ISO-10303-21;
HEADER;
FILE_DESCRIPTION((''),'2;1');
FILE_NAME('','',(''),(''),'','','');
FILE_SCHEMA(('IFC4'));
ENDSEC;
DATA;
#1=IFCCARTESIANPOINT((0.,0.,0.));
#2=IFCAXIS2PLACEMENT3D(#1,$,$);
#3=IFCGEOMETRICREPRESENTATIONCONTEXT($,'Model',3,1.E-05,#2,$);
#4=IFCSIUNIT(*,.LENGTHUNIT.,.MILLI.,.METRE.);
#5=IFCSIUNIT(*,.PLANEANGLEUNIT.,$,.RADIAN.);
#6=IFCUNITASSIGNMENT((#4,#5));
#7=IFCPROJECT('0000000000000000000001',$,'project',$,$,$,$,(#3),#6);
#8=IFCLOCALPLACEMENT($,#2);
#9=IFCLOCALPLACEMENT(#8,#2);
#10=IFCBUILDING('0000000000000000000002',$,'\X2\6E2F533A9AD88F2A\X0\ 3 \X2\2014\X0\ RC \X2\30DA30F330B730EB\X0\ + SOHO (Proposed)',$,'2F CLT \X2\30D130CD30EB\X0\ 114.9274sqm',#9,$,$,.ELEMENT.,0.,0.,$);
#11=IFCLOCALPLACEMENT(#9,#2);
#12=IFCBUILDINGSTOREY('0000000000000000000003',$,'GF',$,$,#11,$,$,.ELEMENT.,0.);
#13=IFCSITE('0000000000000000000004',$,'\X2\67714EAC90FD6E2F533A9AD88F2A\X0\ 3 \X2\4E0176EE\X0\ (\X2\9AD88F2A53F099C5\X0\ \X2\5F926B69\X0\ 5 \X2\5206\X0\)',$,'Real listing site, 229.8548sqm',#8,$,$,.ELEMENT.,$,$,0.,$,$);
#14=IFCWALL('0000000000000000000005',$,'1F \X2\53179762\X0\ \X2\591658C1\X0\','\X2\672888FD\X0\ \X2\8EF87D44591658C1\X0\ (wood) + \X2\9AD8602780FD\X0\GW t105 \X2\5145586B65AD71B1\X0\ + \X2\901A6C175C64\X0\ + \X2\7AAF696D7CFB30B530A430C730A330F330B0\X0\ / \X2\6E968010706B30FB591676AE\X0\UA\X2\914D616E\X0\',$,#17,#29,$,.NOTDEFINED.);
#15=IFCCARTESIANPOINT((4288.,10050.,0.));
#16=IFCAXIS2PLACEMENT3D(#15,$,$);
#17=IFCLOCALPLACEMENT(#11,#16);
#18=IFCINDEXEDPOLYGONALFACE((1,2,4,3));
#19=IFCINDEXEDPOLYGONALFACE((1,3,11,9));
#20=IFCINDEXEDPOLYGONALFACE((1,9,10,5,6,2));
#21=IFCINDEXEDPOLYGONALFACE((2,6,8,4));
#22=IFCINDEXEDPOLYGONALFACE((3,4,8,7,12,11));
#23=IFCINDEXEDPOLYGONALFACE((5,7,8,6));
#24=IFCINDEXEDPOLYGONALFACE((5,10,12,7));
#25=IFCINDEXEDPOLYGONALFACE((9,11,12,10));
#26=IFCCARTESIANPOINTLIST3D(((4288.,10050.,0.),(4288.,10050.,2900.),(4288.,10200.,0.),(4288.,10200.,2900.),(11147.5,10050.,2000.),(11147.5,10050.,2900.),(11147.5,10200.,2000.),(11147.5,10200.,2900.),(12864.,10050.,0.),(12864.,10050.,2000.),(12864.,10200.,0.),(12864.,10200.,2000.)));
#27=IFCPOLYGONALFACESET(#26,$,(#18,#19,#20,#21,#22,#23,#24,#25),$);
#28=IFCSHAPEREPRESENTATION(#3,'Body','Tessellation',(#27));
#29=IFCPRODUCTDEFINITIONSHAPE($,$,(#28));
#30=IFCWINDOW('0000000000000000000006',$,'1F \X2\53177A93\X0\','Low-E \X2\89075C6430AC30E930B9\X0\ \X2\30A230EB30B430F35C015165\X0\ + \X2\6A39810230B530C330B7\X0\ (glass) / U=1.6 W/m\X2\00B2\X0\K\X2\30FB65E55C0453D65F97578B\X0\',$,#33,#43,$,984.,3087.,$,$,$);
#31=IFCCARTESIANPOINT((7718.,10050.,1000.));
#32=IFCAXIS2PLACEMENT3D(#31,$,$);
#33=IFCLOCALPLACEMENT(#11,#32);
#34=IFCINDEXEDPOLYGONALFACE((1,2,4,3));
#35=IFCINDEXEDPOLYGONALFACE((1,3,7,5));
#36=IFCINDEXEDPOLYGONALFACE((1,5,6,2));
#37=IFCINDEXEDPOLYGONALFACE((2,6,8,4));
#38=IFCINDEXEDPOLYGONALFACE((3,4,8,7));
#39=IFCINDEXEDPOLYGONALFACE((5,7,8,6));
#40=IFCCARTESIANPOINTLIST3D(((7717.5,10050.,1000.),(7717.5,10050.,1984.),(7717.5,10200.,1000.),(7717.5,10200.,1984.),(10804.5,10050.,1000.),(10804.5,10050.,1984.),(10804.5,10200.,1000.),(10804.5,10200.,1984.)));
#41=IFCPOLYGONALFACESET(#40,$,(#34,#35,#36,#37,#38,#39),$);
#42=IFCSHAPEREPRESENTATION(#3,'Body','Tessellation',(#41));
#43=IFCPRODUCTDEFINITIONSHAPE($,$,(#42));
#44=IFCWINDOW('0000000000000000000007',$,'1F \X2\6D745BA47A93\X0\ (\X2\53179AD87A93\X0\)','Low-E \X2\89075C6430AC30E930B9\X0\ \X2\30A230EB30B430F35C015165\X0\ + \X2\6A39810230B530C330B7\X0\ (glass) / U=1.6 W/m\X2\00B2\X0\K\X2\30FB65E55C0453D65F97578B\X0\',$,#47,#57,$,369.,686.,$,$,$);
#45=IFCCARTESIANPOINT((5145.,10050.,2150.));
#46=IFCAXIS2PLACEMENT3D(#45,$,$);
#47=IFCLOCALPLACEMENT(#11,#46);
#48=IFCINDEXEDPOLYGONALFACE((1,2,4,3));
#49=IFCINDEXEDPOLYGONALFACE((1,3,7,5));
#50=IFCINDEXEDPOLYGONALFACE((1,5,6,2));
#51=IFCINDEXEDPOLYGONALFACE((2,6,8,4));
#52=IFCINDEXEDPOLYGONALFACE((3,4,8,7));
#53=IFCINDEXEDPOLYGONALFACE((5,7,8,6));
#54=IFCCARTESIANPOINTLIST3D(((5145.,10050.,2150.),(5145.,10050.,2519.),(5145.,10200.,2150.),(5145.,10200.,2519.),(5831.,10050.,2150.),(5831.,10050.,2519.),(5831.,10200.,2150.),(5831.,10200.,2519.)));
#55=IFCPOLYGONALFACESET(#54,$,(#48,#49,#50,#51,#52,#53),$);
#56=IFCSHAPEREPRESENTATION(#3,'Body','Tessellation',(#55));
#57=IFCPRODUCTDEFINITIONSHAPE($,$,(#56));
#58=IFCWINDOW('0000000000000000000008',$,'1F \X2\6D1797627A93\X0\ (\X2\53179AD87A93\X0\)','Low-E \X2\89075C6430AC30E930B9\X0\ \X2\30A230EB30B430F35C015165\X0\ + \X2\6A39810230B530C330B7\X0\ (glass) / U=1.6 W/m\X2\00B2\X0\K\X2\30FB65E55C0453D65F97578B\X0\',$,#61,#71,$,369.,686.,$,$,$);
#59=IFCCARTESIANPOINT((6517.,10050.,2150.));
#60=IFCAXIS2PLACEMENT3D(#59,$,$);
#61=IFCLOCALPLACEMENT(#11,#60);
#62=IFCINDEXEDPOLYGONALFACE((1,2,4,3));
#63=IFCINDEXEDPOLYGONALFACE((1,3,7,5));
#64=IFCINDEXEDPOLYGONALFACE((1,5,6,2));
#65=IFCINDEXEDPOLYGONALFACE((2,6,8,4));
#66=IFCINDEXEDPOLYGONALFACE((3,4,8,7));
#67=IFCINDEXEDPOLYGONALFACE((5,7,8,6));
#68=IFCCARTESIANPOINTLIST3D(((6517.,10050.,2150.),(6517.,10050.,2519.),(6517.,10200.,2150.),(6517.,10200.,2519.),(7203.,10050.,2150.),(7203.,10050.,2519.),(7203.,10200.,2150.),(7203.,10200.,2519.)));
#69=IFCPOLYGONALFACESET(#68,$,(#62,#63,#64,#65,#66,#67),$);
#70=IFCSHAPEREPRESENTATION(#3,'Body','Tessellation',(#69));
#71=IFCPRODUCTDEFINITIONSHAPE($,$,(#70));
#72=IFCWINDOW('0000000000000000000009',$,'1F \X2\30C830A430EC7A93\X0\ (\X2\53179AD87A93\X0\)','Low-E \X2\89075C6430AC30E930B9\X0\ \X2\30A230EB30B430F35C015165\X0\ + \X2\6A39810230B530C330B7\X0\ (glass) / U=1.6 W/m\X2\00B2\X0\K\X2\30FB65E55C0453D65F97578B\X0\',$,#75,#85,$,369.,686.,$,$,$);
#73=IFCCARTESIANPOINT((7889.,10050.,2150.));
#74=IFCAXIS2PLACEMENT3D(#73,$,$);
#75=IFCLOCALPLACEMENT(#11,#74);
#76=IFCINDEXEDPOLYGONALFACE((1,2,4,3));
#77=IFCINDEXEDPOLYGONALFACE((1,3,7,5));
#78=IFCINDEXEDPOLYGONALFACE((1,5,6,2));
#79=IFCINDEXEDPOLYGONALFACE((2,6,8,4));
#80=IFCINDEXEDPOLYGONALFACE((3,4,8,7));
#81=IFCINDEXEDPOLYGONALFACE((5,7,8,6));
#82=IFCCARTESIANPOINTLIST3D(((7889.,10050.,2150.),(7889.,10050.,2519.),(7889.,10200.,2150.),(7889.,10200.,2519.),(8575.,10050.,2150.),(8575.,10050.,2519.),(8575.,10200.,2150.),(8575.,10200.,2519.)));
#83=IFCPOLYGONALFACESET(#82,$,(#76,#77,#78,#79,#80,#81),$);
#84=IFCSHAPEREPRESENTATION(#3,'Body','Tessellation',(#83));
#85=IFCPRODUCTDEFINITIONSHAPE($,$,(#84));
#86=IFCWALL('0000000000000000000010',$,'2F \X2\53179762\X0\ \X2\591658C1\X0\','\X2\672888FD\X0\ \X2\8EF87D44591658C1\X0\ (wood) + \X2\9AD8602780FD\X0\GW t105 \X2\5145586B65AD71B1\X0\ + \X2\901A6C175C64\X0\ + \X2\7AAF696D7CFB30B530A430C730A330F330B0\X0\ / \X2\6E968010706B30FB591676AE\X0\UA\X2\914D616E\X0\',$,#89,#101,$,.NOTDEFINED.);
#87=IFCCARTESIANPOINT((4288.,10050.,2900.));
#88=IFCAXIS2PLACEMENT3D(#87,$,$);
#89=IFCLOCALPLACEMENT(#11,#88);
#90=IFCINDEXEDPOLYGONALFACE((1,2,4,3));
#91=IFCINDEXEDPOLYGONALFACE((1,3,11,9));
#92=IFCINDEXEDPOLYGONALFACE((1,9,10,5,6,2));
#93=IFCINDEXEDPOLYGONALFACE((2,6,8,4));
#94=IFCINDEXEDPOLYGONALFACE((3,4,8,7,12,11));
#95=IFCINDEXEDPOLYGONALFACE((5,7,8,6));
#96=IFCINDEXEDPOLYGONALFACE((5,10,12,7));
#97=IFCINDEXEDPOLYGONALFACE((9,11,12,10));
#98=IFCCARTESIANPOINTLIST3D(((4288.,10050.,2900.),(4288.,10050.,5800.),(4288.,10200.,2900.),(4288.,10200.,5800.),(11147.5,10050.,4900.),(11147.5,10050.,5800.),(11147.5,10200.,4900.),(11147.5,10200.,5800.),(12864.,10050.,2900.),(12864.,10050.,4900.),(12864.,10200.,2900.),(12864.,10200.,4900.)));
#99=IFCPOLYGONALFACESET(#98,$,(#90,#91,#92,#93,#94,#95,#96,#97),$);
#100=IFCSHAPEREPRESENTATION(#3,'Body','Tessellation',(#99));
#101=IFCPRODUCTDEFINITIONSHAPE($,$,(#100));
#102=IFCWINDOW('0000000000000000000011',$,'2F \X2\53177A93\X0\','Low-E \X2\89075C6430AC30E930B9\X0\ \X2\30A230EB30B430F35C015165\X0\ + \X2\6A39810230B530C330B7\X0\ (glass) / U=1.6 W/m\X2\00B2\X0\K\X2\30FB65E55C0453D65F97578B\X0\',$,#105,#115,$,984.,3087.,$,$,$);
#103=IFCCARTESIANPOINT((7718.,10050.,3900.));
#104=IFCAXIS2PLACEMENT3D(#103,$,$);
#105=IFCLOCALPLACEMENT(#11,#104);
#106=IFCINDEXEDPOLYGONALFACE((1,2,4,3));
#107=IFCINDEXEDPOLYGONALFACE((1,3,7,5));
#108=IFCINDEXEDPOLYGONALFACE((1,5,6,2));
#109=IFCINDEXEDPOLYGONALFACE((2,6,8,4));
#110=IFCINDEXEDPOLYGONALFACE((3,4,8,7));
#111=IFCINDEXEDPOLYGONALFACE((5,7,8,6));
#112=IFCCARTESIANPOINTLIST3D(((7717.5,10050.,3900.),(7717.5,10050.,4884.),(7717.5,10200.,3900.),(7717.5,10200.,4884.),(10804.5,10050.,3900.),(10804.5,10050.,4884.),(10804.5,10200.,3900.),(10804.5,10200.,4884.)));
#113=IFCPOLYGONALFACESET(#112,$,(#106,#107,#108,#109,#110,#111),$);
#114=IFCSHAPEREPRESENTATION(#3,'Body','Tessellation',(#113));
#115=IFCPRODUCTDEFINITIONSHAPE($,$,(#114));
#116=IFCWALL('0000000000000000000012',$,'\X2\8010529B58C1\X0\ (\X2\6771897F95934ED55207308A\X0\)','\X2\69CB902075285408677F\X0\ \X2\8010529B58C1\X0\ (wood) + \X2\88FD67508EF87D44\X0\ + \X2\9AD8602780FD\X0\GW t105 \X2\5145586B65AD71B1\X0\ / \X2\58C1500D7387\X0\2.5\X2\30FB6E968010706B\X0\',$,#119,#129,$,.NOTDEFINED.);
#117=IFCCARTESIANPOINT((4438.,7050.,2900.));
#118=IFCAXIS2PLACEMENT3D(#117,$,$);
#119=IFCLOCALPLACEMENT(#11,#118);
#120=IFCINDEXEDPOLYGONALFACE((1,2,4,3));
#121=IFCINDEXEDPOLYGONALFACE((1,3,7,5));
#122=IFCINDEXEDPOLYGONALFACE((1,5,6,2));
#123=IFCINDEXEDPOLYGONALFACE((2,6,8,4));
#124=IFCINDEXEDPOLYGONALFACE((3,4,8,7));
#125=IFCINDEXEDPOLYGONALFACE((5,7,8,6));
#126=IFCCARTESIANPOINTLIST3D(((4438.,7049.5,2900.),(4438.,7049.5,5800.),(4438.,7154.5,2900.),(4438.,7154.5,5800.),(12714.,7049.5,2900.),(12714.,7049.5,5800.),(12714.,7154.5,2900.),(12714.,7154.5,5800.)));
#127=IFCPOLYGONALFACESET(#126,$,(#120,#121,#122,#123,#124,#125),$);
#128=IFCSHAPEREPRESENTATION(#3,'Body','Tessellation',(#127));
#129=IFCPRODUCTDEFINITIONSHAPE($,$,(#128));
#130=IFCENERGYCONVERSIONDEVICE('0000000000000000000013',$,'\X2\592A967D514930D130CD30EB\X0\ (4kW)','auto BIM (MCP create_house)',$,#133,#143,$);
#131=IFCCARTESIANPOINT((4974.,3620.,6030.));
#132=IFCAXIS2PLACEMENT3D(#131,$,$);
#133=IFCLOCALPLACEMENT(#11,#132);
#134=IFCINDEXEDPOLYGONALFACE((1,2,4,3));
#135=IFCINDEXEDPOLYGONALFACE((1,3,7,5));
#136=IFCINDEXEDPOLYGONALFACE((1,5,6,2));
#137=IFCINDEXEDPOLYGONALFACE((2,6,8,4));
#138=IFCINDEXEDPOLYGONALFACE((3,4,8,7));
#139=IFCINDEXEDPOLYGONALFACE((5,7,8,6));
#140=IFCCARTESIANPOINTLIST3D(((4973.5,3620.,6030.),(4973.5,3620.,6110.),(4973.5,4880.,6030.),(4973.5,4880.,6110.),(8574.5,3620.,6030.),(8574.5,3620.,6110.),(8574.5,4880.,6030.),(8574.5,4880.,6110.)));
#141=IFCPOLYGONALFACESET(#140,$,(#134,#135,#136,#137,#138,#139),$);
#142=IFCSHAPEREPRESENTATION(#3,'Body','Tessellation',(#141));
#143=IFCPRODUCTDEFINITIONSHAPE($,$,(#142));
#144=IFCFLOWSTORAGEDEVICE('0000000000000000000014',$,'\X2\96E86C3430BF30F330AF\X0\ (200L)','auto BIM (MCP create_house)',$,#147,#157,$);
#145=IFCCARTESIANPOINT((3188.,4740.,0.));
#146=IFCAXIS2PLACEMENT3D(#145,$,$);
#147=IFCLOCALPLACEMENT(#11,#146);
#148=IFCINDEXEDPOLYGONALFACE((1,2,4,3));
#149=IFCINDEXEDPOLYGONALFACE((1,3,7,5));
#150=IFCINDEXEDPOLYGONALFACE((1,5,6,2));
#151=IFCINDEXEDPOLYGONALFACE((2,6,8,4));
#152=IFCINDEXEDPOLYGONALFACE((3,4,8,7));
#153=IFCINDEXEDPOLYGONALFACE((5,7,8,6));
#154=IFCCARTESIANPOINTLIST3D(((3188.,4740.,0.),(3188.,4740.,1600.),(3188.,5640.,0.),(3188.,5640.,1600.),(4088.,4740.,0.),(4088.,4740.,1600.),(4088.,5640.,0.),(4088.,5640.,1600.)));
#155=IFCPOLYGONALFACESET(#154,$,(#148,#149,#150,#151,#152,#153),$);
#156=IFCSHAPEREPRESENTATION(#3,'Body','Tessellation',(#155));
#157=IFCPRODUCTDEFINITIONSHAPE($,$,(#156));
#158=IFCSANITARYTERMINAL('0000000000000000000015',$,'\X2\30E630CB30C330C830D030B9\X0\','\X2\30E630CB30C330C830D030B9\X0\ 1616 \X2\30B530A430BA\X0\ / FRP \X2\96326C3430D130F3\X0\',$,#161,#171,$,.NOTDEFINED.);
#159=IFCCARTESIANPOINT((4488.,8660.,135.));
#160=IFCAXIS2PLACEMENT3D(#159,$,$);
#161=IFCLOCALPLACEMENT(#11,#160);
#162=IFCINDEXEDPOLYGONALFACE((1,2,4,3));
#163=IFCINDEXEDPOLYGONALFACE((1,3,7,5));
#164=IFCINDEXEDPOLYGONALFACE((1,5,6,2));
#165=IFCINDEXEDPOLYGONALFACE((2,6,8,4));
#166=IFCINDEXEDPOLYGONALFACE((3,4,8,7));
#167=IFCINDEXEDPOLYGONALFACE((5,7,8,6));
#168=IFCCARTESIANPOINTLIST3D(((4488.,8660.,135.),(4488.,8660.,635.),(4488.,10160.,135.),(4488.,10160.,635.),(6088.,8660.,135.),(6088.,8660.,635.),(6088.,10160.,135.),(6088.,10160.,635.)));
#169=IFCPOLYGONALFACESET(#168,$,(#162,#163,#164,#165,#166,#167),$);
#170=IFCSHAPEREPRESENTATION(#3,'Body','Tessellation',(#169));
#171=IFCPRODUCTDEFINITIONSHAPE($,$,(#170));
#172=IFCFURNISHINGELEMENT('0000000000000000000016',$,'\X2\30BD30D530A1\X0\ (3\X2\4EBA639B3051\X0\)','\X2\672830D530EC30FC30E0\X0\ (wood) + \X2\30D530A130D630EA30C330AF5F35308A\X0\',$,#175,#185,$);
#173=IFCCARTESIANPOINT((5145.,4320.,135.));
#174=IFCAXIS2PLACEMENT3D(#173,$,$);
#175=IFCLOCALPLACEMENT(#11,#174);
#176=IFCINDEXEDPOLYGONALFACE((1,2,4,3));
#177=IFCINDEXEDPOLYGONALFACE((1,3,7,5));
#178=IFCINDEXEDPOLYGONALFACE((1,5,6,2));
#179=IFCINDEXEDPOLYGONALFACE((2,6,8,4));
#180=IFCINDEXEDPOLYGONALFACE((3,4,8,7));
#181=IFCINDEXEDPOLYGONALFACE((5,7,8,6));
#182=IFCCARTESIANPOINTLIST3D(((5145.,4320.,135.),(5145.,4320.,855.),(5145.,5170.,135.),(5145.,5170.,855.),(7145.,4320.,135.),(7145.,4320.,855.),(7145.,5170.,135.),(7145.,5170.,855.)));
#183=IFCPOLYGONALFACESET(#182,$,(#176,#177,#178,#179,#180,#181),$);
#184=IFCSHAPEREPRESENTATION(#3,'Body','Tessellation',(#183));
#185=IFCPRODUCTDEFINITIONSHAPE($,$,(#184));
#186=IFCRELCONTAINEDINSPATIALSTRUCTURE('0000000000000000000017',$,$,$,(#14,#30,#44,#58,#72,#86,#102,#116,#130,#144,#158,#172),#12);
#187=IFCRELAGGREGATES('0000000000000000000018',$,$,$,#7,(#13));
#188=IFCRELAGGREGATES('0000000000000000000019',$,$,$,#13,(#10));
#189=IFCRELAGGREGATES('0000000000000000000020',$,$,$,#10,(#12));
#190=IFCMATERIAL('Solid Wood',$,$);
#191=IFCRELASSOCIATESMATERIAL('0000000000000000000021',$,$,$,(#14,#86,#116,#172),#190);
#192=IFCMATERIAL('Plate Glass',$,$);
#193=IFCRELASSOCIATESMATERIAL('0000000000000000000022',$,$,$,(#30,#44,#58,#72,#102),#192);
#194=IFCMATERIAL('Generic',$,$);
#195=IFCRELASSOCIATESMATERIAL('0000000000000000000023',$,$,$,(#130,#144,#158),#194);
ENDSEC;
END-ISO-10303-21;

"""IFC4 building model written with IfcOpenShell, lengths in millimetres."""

from ifc_helpers import new_model, si_unit, frame, frame_2d, origin, place, context, project, spatial, rectangle, extrude, material, element, fill, save


model = new_model("IFC4")

# Units and contexts
model_context = context("Model", 3, precision=1e-05, world=origin())
ifc_project = project(units=[si_unit("LENGTHUNIT", "METRE", prefix="MILLI"), si_unit("PLANEANGLEUNIT", "RADIAN")], contexts=[model_context])

# Site, building, storey
site_placement = place(None, origin())
site = spatial("IfcSite", under=ifc_project, at=site_placement, Name="東京都港区高輪 3 丁目 (高輪台駅 徒歩 5 分)", ObjectType="Real listing site, 229.8548sqm", CompositionType="ELEMENT", RefElevation=0.0)
building_placement = place(site_placement, origin())
building = spatial("IfcBuilding", under=site, at=building_placement, Name="港区高輪 3 — RC ペンシル + SOHO (Proposed)", ObjectType="2F CLT パネル 114.9274sqm", CompositionType="ELEMENT", ElevationOfRefHeight=0.0, ElevationOfTerrain=0.0)
storey_placement = place(building_placement, origin())
storey = spatial("IfcBuildingStorey", under=building, at=storey_placement, Name="GF", CompositionType="ELEMENT", Elevation=0.0)

# Wall, openings, windows
ifc_material_1 = material(Name="Solid Wood")
wall_1_placement = place(storey_placement, frame((4288.0, 10050.0, 0.0)))
wall_1 = element("IfcWall", 1, at=wall_1_placement, inside=storey, material=ifc_material_1, Name="1F 北面 外壁", Description="木製 軸組外壁 (wood) + 高性能GW t105 充填断熱 + 通気層 + 窯業系サイディング / 準耐火・外皮UA配慮", PredefinedType="NOTDEFINED", context=model_context, shape_type="SweptSolid", body=[
    extrude(rectangle(XDim=8576.0, YDim=150.0, at=frame_2d((4288.0, 75.0))), frame((4288.0, 10050.0, 0.0)), (0.0, 0.0, 1.0), 2900.0),
])
opening_1_placement = place(storey_placement, frame((7718.0, 10050.0, 1000.0)))
opening_1 = element("IfcOpeningElement", 2, at=opening_1_placement, cuts=wall_1, PredefinedType="NOTDEFINED", context=model_context, shape_type="SweptSolid", body=[
    extrude(rectangle(XDim=3087.0, YDim=150.0, at=frame_2d((1543.0, 75.0))), frame((7718.0, 10050.0, 1000.0)), (0.0, 0.0, 1.0), 984.0),
])
opening_2_placement = place(storey_placement, frame((5145.0, 10050.0, 2150.0)))
opening_2 = element("IfcOpeningElement", 3, at=opening_2_placement, cuts=wall_1, PredefinedType="NOTDEFINED", context=model_context, shape_type="SweptSolid", body=[
    extrude(rectangle(XDim=686.0, YDim=150.0, at=frame_2d((343.0, 75.0))), frame((5145.0, 10050.0, 2150.0)), (0.0, 0.0, 1.0), 369.0),
])
opening_3_placement = place(storey_placement, frame((6517.0, 10050.0, 2150.0)))
opening_3 = element("IfcOpeningElement", 4, at=opening_3_placement, cuts=wall_1, PredefinedType="NOTDEFINED", context=model_context, shape_type="SweptSolid", body=[
    extrude(rectangle(XDim=686.0, YDim=150.0, at=frame_2d((343.0, 75.0))), frame((6517.0, 10050.0, 2150.0)), (0.0, 0.0, 1.0), 369.0),
])
opening_4_placement = place(storey_placement, frame((7889.0, 10050.0, 2150.0)))
opening_4 = element("IfcOpeningElement", 5, at=opening_4_placement, cuts=wall_1, PredefinedType="NOTDEFINED", context=model_context, shape_type="SweptSolid", body=[
    extrude(rectangle(XDim=686.0, YDim=150.0, at=frame_2d((343.0, 75.0))), frame((7889.0, 10050.0, 2150.0)), (0.0, 0.0, 1.0), 369.0),
])
ifc_material_2 = material(Name="Plate Glass")
window_1_placement = place(storey_placement, frame((7718.0, 10050.0, 1000.0)))
window_1 = element("IfcWindow", 6, at=window_1_placement, inside=storey, material=ifc_material_2, Name="1F 北窓", Description="Low-E 複層ガラス アルゴン封入 + 樹脂サッシ (glass) / U=1.6 W/m²K・日射取得型", OverallHeight=984.0, OverallWidth=3087.0, context=model_context, shape_type="SweptSolid", body=[
    extrude(rectangle(XDim=3087.0, YDim=150.0, at=frame_2d((1543.0, 75.0))), frame((7718.0, 10050.0, 1000.0)), (0.0, 0.0, 1.0), 984.0),
])
fill(opening_1, window_1)
window_2_placement = place(storey_placement, frame((5145.0, 10050.0, 2150.0)))
window_2 = element("IfcWindow", 7, at=window_2_placement, inside=storey, material=ifc_material_2, Name="1F 浴室窓 (北高窓)", Description="Low-E 複層ガラス アルゴン封入 + 樹脂サッシ (glass) / U=1.6 W/m²K・日射取得型", OverallHeight=369.0, OverallWidth=686.0, context=model_context, shape_type="SweptSolid", body=[
    extrude(rectangle(XDim=686.0, YDim=150.0, at=frame_2d((343.0, 75.0))), frame((5145.0, 10050.0, 2150.0)), (0.0, 0.0, 1.0), 369.0),
])
fill(opening_2, window_2)
window_3_placement = place(storey_placement, frame((6517.0, 10050.0, 2150.0)))
window_3 = element("IfcWindow", 8, at=window_3_placement, inside=storey, material=ifc_material_2, Name="1F 洗面窓 (北高窓)", Description="Low-E 複層ガラス アルゴン封入 + 樹脂サッシ (glass) / U=1.6 W/m²K・日射取得型", OverallHeight=369.0, OverallWidth=686.0, context=model_context, shape_type="SweptSolid", body=[
    extrude(rectangle(XDim=686.0, YDim=150.0, at=frame_2d((343.0, 75.0))), frame((6517.0, 10050.0, 2150.0)), (0.0, 0.0, 1.0), 369.0),
])
fill(opening_3, window_3)
window_4_placement = place(storey_placement, frame((7889.0, 10050.0, 2150.0)))
window_4 = element("IfcWindow", 9, at=window_4_placement, inside=storey, material=ifc_material_2, Name="1F トイレ窓 (北高窓)", Description="Low-E 複層ガラス アルゴン封入 + 樹脂サッシ (glass) / U=1.6 W/m²K・日射取得型", OverallHeight=369.0, OverallWidth=686.0, context=model_context, shape_type="SweptSolid", body=[
    extrude(rectangle(XDim=686.0, YDim=150.0, at=frame_2d((343.0, 75.0))), frame((7889.0, 10050.0, 2150.0)), (0.0, 0.0, 1.0), 369.0),
])
fill(opening_4, window_4)

# Wall, opening, window
wall_2_placement = place(storey_placement, frame((4288.0, 10050.0, 2900.0)))
wall_2 = element("IfcWall", 10, at=wall_2_placement, inside=storey, material=ifc_material_1, Name="2F 北面 外壁", Description="木製 軸組外壁 (wood) + 高性能GW t105 充填断熱 + 通気層 + 窯業系サイディング / 準耐火・外皮UA配慮", PredefinedType="NOTDEFINED", context=model_context, shape_type="SweptSolid", body=[
    extrude(rectangle(XDim=8576.0, YDim=150.0, at=frame_2d((4288.0, 75.0))), frame((4288.0, 10050.0, 2900.0)), (0.0, 0.0, 1.0), 2900.0),
])
opening_5_placement = place(storey_placement, frame((7718.0, 10050.0, 3900.0)))
opening_5 = element("IfcOpeningElement", 11, at=opening_5_placement, cuts=wall_2, PredefinedType="NOTDEFINED", context=model_context, shape_type="SweptSolid", body=[
    extrude(rectangle(XDim=3087.0, YDim=150.0, at=frame_2d((1543.0, 75.0))), frame((7718.0, 10050.0, 3900.0)), (0.0, 0.0, 1.0), 984.0),
])
window_5_placement = place(storey_placement, frame((7718.0, 10050.0, 3900.0)))
window_5 = element("IfcWindow", 12, at=window_5_placement, inside=storey, material=ifc_material_2, Name="2F 北窓", Description="Low-E 複層ガラス アルゴン封入 + 樹脂サッシ (glass) / U=1.6 W/m²K・日射取得型", OverallHeight=984.0, OverallWidth=3087.0, context=model_context, shape_type="SweptSolid", body=[
    extrude(rectangle(XDim=3087.0, YDim=150.0, at=frame_2d((1543.0, 75.0))), frame((7718.0, 10050.0, 3900.0)), (0.0, 0.0, 1.0), 984.0),
])
fill(opening_5, window_5)

# Wall
wall_3_placement = place(storey_placement, frame((4438.0, 7050.0, 2900.0)))
element("IfcWall", 13, at=wall_3_placement, inside=storey, material=ifc_material_1, Name="耐力壁 (東西間仕切り)", Description="構造用合板 耐力壁 (wood) + 製材軸組 + 高性能GW t105 充填断熱 / 壁倍率2.5・準耐火", PredefinedType="NOTDEFINED", context=model_context, shape_type="SweptSolid", body=[
    extrude(rectangle(XDim=8276.0, YDim=105.0, at=frame_2d((4138.0, 52.0))), frame((4438.0, 7050.0, 2900.0)), (0.0, 0.0, 1.0), 2900.0),
])

# Energy conversion device
ifc_material_3 = material(Name="Generic")
energy_conversion_device_placement = place(storey_placement, frame((4974.0, 3620.0, 6030.0)))
element("IfcEnergyConversionDevice", 14, at=energy_conversion_device_placement, inside=storey, material=ifc_material_3, Name="太陽光パネル (4kW)", Description="auto BIM (MCP create_house)", context=model_context, shape_type="SweptSolid", body=[
    extrude(rectangle(XDim=3601.0, YDim=1260.0, at=frame_2d((1800.0, 630.0))), frame((4974.0, 3620.0, 6030.0)), (0.0, 0.0, 1.0), 80.0),
])

# Flow storage device
flow_storage_device_placement = place(storey_placement, frame((3188.0, 4740.0, 0.0)))
element("IfcFlowStorageDevice", 15, at=flow_storage_device_placement, inside=storey, material=ifc_material_3, Name="雨水タンク (200L)", Description="auto BIM (MCP create_house)", context=model_context, shape_type="SweptSolid", body=[
    extrude(rectangle(XDim=900.0, YDim=900.0, at=frame_2d((450.0, 450.0))), frame((3188.0, 4740.0, 0.0)), (0.0, 0.0, 1.0), 1600.0),
])

# Sanitary terminal
sanitary_terminal_placement = place(storey_placement, frame((4488.0, 8660.0, 135.0)))
element("IfcSanitaryTerminal", 16, at=sanitary_terminal_placement, inside=storey, material=ifc_material_3, Name="ユニットバス", Description="ユニットバス 1616 サイズ / FRP 防水パン", PredefinedType="NOTDEFINED", context=model_context, shape_type="SweptSolid", body=[
    extrude(rectangle(XDim=1600.0, YDim=1500.0, at=frame_2d((800.0, 750.0))), frame((4488.0, 8660.0, 135.0)), (0.0, 0.0, 1.0), 500.0),
])

# Furnishing element
furnishing_1_placement = place(storey_placement, frame((5145.0, 4320.0, 135.0)))
element("IfcFurnishingElement", 17, at=furnishing_1_placement, inside=storey, material=ifc_material_1, Name="ソファ (3人掛け)", Description="木フレーム (wood) + ファブリック張り", context=model_context, shape_type="SweptSolid", body=[
    extrude(rectangle(XDim=2000.0, YDim=850.0, at=frame_2d((1000.0, 425.0))), frame((5145.0, 4320.0, 135.0)), (0.0, 0.0, 1.0), 720.0),
])

save(model, "model.ifc")
